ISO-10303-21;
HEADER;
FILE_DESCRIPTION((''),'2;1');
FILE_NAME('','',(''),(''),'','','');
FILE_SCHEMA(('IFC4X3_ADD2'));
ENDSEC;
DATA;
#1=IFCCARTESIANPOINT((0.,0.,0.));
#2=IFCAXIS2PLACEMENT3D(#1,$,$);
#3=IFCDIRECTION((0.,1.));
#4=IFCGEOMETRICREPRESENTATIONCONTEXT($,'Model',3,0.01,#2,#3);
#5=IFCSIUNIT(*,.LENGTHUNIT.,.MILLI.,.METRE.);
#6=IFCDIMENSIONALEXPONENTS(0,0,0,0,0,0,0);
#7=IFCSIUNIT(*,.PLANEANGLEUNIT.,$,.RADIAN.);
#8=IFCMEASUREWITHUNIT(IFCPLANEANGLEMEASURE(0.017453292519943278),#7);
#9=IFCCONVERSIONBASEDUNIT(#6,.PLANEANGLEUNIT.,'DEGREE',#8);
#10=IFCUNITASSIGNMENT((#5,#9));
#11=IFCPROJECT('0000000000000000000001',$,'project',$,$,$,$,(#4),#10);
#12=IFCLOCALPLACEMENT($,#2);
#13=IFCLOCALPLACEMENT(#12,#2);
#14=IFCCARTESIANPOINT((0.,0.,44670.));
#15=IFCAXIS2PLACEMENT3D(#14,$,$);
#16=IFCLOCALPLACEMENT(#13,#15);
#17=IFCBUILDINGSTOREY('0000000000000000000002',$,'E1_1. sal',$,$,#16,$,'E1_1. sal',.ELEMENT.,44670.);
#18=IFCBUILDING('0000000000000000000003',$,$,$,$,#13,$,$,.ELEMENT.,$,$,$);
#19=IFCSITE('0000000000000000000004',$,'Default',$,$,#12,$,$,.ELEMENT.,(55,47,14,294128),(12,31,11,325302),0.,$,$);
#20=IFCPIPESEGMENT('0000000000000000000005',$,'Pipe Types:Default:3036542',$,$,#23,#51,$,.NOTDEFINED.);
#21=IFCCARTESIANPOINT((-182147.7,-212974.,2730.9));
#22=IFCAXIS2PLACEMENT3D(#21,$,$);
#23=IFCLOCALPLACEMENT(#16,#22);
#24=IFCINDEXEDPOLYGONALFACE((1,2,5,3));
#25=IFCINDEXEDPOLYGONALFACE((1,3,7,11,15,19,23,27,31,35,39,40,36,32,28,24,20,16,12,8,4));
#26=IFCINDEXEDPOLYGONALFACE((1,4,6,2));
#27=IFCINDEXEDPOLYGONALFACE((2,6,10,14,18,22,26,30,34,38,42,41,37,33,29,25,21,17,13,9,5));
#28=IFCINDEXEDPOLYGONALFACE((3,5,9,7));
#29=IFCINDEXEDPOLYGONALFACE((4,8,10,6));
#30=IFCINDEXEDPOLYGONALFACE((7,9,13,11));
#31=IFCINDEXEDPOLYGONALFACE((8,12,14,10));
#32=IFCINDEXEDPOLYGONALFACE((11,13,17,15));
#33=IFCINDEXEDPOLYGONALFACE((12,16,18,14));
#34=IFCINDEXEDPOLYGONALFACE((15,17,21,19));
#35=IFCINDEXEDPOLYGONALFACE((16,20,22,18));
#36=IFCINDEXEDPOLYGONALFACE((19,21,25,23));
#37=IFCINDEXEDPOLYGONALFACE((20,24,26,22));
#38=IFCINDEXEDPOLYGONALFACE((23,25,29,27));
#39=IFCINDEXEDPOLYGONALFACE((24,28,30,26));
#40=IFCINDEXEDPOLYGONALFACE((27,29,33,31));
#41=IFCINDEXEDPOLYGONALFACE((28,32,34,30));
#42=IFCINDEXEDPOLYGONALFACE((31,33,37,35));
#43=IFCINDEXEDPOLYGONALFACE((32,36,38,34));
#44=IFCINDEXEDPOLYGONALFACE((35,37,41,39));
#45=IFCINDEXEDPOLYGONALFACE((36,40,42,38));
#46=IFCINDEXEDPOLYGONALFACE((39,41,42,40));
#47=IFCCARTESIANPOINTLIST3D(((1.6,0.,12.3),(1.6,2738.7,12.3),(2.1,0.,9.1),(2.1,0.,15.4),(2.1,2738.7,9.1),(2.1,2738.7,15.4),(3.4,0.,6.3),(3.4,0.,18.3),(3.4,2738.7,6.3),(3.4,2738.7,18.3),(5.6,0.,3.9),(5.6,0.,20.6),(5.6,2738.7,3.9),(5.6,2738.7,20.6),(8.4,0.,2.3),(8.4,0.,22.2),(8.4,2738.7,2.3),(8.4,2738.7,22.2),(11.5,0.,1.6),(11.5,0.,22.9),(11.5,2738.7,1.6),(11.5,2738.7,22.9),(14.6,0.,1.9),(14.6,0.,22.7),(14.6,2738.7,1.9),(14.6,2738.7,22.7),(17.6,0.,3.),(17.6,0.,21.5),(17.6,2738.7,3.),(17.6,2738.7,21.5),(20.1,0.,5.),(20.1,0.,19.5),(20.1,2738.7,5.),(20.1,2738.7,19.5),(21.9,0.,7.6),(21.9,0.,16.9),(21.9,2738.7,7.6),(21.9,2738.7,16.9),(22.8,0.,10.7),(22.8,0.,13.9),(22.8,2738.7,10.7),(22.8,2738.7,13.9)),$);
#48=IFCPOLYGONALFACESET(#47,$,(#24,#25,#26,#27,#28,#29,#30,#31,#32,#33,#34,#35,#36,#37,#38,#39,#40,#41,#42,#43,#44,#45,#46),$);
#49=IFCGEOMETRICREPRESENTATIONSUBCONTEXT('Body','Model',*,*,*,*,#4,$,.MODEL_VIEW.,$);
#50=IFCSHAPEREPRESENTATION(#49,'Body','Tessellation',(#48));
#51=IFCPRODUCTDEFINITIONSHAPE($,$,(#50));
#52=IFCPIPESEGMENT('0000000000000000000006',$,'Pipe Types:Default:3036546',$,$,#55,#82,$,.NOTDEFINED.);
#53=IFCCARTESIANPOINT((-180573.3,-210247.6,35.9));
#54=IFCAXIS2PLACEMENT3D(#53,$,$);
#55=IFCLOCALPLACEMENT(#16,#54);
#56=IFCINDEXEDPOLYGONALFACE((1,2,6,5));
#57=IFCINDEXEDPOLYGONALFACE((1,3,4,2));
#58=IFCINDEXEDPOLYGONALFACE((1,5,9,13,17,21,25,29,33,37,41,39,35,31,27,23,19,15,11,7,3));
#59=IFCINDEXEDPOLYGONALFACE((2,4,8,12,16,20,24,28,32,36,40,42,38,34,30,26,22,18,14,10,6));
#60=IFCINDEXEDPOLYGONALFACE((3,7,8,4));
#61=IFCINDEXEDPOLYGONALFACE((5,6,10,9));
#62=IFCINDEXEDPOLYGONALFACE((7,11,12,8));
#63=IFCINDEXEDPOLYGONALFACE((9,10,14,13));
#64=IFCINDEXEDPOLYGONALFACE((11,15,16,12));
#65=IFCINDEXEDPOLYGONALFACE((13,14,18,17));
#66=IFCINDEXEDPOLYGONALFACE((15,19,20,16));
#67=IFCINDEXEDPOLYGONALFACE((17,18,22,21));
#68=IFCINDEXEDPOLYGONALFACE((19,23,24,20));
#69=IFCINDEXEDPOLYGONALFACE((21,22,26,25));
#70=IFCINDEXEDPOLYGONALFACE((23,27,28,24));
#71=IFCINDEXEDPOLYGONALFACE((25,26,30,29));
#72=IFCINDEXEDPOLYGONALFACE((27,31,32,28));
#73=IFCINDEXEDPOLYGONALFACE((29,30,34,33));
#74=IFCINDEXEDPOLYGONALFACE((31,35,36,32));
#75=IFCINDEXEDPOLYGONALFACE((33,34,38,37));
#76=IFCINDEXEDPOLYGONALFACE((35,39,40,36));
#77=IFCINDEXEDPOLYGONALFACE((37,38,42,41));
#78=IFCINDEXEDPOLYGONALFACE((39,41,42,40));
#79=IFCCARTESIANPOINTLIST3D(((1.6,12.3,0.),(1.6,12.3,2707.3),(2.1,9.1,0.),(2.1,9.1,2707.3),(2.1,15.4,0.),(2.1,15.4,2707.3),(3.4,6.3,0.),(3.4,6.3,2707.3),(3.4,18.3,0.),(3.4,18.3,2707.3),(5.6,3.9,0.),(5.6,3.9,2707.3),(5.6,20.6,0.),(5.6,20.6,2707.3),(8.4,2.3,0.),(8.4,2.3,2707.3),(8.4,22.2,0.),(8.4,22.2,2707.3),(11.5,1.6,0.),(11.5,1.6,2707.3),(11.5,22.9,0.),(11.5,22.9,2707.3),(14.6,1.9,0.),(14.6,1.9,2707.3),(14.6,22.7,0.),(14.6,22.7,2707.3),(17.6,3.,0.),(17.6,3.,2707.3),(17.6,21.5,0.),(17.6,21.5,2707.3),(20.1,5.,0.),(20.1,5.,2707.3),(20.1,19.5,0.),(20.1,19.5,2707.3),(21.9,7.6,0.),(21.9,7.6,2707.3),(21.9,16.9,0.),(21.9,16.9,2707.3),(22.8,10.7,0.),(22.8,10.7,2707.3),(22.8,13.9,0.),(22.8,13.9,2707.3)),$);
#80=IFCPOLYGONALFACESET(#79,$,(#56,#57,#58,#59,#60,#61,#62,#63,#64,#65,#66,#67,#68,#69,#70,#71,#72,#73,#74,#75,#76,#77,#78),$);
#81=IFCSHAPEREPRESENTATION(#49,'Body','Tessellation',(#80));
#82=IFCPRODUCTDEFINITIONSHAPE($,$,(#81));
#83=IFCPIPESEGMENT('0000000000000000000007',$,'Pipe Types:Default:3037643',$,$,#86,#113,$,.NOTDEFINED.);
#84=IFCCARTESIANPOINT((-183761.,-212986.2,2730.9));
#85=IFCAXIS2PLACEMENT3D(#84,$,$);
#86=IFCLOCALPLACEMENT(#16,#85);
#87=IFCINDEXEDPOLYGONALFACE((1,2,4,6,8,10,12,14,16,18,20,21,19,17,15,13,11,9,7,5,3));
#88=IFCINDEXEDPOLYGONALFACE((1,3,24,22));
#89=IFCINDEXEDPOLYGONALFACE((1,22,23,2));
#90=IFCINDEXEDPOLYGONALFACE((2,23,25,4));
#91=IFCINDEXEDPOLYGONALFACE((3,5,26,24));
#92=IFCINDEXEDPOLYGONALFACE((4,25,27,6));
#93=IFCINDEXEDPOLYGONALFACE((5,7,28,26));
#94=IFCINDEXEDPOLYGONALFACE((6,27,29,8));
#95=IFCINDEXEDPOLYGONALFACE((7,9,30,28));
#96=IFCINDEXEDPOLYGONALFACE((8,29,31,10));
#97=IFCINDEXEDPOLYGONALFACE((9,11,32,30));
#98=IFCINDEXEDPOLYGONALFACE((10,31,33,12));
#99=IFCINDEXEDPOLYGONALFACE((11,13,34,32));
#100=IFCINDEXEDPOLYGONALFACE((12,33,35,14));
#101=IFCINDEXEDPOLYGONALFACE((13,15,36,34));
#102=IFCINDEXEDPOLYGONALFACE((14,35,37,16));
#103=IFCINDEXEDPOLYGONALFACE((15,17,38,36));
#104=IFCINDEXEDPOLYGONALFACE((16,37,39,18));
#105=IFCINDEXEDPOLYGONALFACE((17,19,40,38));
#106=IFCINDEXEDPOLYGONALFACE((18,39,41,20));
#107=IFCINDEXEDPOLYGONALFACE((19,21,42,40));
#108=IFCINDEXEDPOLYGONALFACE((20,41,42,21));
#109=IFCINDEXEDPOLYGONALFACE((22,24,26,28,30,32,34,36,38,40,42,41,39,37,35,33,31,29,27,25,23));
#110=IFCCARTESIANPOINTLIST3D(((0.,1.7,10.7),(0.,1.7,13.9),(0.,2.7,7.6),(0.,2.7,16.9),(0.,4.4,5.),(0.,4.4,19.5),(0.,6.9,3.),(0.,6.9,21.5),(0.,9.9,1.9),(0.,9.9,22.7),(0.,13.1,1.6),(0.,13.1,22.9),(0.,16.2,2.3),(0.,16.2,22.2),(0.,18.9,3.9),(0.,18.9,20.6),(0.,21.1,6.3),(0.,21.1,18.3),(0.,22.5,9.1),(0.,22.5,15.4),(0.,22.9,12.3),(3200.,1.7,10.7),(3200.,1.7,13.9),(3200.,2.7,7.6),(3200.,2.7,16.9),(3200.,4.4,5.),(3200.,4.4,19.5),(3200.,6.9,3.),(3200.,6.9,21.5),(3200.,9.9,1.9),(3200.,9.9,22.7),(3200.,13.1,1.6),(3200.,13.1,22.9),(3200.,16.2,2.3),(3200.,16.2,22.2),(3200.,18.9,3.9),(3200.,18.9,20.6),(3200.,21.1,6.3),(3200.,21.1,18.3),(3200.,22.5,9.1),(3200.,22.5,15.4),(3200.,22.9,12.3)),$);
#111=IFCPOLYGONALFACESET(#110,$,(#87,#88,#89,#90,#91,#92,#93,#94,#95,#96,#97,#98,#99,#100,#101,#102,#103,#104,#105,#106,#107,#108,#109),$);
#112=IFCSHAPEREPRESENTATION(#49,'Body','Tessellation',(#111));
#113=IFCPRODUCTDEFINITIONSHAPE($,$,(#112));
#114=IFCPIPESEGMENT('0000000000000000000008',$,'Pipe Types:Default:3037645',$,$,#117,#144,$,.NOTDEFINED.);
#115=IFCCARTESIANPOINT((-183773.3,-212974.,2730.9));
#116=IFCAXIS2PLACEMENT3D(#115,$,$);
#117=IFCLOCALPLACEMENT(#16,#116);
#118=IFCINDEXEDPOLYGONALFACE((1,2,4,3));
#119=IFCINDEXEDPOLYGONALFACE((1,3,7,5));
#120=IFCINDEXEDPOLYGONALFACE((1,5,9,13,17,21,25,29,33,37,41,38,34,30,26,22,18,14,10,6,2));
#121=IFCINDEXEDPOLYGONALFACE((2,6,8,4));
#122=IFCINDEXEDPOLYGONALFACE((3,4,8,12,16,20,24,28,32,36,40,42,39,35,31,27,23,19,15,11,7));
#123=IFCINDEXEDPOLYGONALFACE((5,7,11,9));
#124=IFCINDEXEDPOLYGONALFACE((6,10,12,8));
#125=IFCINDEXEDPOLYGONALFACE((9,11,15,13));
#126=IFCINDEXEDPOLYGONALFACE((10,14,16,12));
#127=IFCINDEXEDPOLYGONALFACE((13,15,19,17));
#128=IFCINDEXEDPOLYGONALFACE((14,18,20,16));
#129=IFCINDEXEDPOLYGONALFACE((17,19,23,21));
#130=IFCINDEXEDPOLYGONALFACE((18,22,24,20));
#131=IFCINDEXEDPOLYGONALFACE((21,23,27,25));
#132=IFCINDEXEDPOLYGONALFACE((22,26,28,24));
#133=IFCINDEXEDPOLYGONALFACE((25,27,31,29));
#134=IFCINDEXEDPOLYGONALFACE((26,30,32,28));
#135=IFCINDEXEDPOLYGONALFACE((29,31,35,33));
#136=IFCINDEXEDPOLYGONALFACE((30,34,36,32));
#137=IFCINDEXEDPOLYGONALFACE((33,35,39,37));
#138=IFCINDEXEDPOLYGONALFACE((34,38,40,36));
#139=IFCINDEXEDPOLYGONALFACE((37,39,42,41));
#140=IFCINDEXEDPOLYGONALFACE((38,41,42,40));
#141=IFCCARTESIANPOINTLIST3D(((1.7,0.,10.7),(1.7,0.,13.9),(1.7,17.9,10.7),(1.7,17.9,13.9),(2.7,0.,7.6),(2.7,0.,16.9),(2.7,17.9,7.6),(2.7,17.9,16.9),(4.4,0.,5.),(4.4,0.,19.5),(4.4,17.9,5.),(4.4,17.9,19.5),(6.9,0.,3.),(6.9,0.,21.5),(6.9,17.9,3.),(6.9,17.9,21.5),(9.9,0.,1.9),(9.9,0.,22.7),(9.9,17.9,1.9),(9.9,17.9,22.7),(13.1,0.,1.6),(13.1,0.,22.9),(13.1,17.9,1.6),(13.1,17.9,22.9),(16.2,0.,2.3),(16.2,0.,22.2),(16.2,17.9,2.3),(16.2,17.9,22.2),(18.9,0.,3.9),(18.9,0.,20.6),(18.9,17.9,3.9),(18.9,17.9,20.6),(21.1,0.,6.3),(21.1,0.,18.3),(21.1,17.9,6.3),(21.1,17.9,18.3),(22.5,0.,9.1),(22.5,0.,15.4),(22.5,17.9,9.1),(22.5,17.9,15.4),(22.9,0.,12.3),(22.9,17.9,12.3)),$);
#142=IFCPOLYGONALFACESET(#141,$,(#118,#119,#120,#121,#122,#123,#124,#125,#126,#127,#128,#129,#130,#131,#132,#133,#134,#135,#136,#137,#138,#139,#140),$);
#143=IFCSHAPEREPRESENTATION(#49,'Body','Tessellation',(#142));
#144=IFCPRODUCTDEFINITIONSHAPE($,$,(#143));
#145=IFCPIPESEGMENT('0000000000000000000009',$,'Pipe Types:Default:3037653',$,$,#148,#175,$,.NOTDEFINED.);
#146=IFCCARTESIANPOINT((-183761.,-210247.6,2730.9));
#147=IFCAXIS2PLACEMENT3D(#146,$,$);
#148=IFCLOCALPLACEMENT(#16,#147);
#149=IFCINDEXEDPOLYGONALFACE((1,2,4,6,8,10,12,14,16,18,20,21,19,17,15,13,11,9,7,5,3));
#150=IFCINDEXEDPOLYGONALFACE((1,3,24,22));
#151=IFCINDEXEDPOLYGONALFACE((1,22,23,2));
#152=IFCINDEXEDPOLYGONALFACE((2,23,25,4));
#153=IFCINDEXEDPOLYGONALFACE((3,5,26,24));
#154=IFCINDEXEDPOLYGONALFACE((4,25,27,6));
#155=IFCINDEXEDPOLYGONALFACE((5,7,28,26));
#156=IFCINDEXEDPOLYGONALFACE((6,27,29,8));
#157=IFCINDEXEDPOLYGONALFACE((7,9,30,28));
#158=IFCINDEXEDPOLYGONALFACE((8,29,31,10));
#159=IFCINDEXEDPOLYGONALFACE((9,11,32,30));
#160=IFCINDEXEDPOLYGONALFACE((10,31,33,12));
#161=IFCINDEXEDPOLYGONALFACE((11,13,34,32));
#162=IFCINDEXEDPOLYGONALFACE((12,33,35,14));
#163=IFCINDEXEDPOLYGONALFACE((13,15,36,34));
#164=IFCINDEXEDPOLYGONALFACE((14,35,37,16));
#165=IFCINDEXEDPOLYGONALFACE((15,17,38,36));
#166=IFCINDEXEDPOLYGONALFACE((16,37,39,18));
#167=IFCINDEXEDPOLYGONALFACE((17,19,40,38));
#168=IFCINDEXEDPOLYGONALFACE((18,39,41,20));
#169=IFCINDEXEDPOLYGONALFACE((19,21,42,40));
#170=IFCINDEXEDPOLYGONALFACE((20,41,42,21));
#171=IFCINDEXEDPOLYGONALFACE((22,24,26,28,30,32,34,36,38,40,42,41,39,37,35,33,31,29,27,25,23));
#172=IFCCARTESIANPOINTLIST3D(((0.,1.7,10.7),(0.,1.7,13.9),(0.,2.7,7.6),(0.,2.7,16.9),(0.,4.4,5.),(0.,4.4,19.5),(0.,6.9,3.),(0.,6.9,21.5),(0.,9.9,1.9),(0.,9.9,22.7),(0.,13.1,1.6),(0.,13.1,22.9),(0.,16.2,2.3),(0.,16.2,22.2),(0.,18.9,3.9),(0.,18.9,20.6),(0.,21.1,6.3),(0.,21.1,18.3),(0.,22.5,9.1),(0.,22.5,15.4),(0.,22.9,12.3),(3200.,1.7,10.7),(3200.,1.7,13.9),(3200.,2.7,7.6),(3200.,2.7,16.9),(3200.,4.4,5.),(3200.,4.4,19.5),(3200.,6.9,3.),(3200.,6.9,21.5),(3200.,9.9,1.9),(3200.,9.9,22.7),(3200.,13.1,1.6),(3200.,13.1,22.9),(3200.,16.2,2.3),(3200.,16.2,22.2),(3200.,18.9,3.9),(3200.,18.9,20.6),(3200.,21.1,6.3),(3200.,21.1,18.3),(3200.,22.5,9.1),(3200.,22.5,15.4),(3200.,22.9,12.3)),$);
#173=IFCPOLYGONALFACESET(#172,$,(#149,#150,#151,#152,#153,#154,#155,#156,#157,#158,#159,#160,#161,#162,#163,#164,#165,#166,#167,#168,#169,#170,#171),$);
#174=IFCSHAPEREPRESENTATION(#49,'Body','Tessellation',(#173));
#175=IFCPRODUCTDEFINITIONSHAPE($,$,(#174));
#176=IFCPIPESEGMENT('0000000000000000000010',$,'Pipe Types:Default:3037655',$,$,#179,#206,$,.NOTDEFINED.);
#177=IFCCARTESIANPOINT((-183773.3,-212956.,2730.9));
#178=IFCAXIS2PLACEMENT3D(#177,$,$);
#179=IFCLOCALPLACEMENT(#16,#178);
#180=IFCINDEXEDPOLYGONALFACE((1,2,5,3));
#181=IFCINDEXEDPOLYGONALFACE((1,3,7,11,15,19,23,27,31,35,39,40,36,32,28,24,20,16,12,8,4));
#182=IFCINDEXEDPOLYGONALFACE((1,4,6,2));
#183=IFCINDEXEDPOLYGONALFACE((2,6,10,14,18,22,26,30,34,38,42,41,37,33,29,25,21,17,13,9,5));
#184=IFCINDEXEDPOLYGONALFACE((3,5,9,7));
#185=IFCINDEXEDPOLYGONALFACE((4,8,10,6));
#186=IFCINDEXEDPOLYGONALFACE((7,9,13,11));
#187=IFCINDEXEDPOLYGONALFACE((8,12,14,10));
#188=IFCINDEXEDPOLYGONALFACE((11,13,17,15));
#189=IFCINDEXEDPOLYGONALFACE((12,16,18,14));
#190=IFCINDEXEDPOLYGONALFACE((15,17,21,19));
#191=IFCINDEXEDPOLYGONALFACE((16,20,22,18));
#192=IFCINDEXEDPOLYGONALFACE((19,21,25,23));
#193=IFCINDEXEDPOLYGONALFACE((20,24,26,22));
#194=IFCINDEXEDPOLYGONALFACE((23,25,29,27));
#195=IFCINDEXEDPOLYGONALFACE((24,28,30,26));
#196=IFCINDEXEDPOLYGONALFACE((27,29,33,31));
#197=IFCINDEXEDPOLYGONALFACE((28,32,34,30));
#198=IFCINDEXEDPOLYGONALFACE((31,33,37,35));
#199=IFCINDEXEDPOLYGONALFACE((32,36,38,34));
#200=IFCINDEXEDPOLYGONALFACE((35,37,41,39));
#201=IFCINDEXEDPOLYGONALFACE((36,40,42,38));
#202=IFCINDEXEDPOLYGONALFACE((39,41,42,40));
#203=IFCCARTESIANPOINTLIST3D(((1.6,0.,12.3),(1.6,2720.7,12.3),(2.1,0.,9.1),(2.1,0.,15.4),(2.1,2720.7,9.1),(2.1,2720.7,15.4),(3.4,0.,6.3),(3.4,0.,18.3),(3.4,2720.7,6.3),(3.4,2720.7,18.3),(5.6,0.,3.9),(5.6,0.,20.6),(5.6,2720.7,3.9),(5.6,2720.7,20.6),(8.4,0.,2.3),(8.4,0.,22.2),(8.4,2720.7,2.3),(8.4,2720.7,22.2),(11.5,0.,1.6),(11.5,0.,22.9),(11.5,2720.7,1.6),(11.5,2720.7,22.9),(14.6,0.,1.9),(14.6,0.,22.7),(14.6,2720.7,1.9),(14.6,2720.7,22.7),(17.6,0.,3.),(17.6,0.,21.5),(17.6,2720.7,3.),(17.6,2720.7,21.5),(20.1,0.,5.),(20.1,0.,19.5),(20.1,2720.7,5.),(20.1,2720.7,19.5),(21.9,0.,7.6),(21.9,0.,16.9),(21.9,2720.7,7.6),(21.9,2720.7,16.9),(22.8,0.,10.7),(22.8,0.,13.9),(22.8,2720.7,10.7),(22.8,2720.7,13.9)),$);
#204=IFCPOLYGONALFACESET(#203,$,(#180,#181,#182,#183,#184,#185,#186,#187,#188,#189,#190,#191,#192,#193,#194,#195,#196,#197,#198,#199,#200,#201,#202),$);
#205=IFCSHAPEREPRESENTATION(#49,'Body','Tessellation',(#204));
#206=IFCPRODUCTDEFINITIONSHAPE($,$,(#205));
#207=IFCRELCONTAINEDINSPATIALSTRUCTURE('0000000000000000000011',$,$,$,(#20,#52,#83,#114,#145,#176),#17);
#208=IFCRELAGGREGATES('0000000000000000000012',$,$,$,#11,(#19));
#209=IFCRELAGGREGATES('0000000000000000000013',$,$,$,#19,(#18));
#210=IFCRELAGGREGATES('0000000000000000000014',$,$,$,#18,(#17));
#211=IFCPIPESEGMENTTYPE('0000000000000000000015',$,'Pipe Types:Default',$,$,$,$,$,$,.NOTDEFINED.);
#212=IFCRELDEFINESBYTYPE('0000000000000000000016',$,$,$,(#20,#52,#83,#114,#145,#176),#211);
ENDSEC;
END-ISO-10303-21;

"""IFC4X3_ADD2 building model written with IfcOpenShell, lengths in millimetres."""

from ifc_helpers import new_model, entity, si_unit, converted_unit, direction, frame, frame_2d, origin, origin_2d_with_axis, place, context, subcontext, project, spatial, circle, extrude, type_object, element, save


model = new_model("IFC4X3_ADD2")

# Units and contexts
model_context = context("Model", 3, precision=0.01, world=origin(), true_north=direction((0.0, 1.0)))
body_context = subcontext(model_context, "Body", "Model", "MODEL_VIEW")
ifc_project = project(units=[si_unit("LENGTHUNIT", "METRE", prefix="MILLI"), converted_unit("PLANEANGLEUNIT", "DEGREE", entity("IfcPlaneAngleMeasure", 0.017453292519943278), si_unit("PLANEANGLEUNIT", "RADIAN"), dimensions=[0, 0, 0, 0, 0, 0, 0])], contexts=[model_context])

# Site, building, storey
site_placement = place(None, origin())
site = spatial("IfcSite", under=ifc_project, at=site_placement, Name="Default", CompositionType="ELEMENT", RefLatitude=(55, 47, 14, 294128), RefLongitude=(12, 31, 11, 325302), RefElevation=0.0)
building_placement = place(site_placement, origin())
building = spatial("IfcBuilding", under=site, at=building_placement, CompositionType="ELEMENT")
storey_placement = place(building_placement, frame((0.0, 0.0, 44670.0)))
storey = spatial("IfcBuildingStorey", under=building, at=storey_placement, Name="E1_1. sal", LongName="E1_1. sal", CompositionType="ELEMENT", Elevation=44670.0)

# Pipe segments
pipe_segment_type = type_object("IfcPipeSegmentType", Name="Pipe Types:Default", PredefinedType="NOTDEFINED")
pipe_segment_1_placement = place(storey_placement, frame((-182147.7, -212974.0, 2730.9)))
element("IfcPipeSegment", 1, at=pipe_segment_1_placement, inside=storey, type_object=pipe_segment_type, Name="Pipe Types:Default:3036542", PredefinedType="NOTDEFINED", context=body_context, shape_type="SweptSolid", body=[
    extrude(circle(Radius=10.7, at=origin_2d_with_axis()), frame((12.3, 0.0, 12.3), z_axis=(0.0, 1.0, 0.0), x_axis=(-1.0, 0.0, 0.0)), (0.0, 0.0, 1.0), 2738.7),
])
pipe_segment_2_placement = place(storey_placement, frame((-180573.3, -210247.6, 35.9)))
element("IfcPipeSegment", 2, at=pipe_segment_2_placement, inside=storey, type_object=pipe_segment_type, Name="Pipe Types:Default:3036546", PredefinedType="NOTDEFINED", context=body_context, shape_type="SweptSolid", body=[
    extrude(circle(Radius=10.7, at=frame_2d((0.0, 0.0), x_axis=(1.0, 0.0))), frame((12.3, 12.3, 0.0), z_axis=(0.0, 0.0, 1.0), x_axis=(-1.0, 0.0, 0.0)), (0.0, 0.0, 1.0), 2707.3),
])
pipe_segment_3_placement = place(storey_placement, frame((-183761.0, -212986.2, 2730.9)))
element("IfcPipeSegment", 3, at=pipe_segment_3_placement, inside=storey, type_object=pipe_segment_type, Name="Pipe Types:Default:3037643", PredefinedType="NOTDEFINED", context=body_context, shape_type="SweptSolid", body=[
    extrude(circle(Radius=10.7, at=origin_2d_with_axis()), frame((0.0, 12.3, 12.3), z_axis=(1.0, 0.0, 0.0), x_axis=(0.0, 1.0, 0.0)), (0.0, 0.0, 1.0), 3200.0),
])
pipe_segment_4_placement = place(storey_placement, frame((-183773.3, -212974.0, 2730.9)))
element("IfcPipeSegment", 4, at=pipe_segment_4_placement, inside=storey, type_object=pipe_segment_type, Name="Pipe Types:Default:3037645", PredefinedType="NOTDEFINED", context=body_context, shape_type="SweptSolid", body=[
    extrude(circle(Radius=10.7, at=origin_2d_with_axis()), frame((12.3, 0.0, 12.3), z_axis=(0.0, 1.0, 0.0), x_axis=(1.0, 0.0, 0.0)), (0.0, 0.0, 1.0), 17.9),
])
pipe_segment_5_placement = place(storey_placement, frame((-183761.0, -210247.6, 2730.9)))
element("IfcPipeSegment", 5, at=pipe_segment_5_placement, inside=storey, type_object=pipe_segment_type, Name="Pipe Types:Default:3037653", PredefinedType="NOTDEFINED", context=body_context, shape_type="SweptSolid", body=[
    extrude(circle(Radius=10.7, at=origin_2d_with_axis()), frame((0.0, 12.3, 12.3), z_axis=(1.0, 0.0, 0.0), x_axis=(0.0, 1.0, 0.0)), (0.0, 0.0, 1.0), 3200.0),
])
pipe_segment_6_placement = place(storey_placement, frame((-183773.3, -212956.0, 2730.9)))
element("IfcPipeSegment", 6, at=pipe_segment_6_placement, inside=storey, type_object=pipe_segment_type, Name="Pipe Types:Default:3037655", PredefinedType="NOTDEFINED", context=body_context, shape_type="SweptSolid", body=[
    extrude(circle(Radius=10.7, at=frame_2d((0.0, 0.0), x_axis=(1.0, 0.0))), frame((12.3, 0.0, 12.3), z_axis=(0.0, 1.0, 0.0), x_axis=(-1.0, 0.0, 0.0)), (0.0, 0.0, 1.0), 2720.7),
])

save(model, "model.ifc")
